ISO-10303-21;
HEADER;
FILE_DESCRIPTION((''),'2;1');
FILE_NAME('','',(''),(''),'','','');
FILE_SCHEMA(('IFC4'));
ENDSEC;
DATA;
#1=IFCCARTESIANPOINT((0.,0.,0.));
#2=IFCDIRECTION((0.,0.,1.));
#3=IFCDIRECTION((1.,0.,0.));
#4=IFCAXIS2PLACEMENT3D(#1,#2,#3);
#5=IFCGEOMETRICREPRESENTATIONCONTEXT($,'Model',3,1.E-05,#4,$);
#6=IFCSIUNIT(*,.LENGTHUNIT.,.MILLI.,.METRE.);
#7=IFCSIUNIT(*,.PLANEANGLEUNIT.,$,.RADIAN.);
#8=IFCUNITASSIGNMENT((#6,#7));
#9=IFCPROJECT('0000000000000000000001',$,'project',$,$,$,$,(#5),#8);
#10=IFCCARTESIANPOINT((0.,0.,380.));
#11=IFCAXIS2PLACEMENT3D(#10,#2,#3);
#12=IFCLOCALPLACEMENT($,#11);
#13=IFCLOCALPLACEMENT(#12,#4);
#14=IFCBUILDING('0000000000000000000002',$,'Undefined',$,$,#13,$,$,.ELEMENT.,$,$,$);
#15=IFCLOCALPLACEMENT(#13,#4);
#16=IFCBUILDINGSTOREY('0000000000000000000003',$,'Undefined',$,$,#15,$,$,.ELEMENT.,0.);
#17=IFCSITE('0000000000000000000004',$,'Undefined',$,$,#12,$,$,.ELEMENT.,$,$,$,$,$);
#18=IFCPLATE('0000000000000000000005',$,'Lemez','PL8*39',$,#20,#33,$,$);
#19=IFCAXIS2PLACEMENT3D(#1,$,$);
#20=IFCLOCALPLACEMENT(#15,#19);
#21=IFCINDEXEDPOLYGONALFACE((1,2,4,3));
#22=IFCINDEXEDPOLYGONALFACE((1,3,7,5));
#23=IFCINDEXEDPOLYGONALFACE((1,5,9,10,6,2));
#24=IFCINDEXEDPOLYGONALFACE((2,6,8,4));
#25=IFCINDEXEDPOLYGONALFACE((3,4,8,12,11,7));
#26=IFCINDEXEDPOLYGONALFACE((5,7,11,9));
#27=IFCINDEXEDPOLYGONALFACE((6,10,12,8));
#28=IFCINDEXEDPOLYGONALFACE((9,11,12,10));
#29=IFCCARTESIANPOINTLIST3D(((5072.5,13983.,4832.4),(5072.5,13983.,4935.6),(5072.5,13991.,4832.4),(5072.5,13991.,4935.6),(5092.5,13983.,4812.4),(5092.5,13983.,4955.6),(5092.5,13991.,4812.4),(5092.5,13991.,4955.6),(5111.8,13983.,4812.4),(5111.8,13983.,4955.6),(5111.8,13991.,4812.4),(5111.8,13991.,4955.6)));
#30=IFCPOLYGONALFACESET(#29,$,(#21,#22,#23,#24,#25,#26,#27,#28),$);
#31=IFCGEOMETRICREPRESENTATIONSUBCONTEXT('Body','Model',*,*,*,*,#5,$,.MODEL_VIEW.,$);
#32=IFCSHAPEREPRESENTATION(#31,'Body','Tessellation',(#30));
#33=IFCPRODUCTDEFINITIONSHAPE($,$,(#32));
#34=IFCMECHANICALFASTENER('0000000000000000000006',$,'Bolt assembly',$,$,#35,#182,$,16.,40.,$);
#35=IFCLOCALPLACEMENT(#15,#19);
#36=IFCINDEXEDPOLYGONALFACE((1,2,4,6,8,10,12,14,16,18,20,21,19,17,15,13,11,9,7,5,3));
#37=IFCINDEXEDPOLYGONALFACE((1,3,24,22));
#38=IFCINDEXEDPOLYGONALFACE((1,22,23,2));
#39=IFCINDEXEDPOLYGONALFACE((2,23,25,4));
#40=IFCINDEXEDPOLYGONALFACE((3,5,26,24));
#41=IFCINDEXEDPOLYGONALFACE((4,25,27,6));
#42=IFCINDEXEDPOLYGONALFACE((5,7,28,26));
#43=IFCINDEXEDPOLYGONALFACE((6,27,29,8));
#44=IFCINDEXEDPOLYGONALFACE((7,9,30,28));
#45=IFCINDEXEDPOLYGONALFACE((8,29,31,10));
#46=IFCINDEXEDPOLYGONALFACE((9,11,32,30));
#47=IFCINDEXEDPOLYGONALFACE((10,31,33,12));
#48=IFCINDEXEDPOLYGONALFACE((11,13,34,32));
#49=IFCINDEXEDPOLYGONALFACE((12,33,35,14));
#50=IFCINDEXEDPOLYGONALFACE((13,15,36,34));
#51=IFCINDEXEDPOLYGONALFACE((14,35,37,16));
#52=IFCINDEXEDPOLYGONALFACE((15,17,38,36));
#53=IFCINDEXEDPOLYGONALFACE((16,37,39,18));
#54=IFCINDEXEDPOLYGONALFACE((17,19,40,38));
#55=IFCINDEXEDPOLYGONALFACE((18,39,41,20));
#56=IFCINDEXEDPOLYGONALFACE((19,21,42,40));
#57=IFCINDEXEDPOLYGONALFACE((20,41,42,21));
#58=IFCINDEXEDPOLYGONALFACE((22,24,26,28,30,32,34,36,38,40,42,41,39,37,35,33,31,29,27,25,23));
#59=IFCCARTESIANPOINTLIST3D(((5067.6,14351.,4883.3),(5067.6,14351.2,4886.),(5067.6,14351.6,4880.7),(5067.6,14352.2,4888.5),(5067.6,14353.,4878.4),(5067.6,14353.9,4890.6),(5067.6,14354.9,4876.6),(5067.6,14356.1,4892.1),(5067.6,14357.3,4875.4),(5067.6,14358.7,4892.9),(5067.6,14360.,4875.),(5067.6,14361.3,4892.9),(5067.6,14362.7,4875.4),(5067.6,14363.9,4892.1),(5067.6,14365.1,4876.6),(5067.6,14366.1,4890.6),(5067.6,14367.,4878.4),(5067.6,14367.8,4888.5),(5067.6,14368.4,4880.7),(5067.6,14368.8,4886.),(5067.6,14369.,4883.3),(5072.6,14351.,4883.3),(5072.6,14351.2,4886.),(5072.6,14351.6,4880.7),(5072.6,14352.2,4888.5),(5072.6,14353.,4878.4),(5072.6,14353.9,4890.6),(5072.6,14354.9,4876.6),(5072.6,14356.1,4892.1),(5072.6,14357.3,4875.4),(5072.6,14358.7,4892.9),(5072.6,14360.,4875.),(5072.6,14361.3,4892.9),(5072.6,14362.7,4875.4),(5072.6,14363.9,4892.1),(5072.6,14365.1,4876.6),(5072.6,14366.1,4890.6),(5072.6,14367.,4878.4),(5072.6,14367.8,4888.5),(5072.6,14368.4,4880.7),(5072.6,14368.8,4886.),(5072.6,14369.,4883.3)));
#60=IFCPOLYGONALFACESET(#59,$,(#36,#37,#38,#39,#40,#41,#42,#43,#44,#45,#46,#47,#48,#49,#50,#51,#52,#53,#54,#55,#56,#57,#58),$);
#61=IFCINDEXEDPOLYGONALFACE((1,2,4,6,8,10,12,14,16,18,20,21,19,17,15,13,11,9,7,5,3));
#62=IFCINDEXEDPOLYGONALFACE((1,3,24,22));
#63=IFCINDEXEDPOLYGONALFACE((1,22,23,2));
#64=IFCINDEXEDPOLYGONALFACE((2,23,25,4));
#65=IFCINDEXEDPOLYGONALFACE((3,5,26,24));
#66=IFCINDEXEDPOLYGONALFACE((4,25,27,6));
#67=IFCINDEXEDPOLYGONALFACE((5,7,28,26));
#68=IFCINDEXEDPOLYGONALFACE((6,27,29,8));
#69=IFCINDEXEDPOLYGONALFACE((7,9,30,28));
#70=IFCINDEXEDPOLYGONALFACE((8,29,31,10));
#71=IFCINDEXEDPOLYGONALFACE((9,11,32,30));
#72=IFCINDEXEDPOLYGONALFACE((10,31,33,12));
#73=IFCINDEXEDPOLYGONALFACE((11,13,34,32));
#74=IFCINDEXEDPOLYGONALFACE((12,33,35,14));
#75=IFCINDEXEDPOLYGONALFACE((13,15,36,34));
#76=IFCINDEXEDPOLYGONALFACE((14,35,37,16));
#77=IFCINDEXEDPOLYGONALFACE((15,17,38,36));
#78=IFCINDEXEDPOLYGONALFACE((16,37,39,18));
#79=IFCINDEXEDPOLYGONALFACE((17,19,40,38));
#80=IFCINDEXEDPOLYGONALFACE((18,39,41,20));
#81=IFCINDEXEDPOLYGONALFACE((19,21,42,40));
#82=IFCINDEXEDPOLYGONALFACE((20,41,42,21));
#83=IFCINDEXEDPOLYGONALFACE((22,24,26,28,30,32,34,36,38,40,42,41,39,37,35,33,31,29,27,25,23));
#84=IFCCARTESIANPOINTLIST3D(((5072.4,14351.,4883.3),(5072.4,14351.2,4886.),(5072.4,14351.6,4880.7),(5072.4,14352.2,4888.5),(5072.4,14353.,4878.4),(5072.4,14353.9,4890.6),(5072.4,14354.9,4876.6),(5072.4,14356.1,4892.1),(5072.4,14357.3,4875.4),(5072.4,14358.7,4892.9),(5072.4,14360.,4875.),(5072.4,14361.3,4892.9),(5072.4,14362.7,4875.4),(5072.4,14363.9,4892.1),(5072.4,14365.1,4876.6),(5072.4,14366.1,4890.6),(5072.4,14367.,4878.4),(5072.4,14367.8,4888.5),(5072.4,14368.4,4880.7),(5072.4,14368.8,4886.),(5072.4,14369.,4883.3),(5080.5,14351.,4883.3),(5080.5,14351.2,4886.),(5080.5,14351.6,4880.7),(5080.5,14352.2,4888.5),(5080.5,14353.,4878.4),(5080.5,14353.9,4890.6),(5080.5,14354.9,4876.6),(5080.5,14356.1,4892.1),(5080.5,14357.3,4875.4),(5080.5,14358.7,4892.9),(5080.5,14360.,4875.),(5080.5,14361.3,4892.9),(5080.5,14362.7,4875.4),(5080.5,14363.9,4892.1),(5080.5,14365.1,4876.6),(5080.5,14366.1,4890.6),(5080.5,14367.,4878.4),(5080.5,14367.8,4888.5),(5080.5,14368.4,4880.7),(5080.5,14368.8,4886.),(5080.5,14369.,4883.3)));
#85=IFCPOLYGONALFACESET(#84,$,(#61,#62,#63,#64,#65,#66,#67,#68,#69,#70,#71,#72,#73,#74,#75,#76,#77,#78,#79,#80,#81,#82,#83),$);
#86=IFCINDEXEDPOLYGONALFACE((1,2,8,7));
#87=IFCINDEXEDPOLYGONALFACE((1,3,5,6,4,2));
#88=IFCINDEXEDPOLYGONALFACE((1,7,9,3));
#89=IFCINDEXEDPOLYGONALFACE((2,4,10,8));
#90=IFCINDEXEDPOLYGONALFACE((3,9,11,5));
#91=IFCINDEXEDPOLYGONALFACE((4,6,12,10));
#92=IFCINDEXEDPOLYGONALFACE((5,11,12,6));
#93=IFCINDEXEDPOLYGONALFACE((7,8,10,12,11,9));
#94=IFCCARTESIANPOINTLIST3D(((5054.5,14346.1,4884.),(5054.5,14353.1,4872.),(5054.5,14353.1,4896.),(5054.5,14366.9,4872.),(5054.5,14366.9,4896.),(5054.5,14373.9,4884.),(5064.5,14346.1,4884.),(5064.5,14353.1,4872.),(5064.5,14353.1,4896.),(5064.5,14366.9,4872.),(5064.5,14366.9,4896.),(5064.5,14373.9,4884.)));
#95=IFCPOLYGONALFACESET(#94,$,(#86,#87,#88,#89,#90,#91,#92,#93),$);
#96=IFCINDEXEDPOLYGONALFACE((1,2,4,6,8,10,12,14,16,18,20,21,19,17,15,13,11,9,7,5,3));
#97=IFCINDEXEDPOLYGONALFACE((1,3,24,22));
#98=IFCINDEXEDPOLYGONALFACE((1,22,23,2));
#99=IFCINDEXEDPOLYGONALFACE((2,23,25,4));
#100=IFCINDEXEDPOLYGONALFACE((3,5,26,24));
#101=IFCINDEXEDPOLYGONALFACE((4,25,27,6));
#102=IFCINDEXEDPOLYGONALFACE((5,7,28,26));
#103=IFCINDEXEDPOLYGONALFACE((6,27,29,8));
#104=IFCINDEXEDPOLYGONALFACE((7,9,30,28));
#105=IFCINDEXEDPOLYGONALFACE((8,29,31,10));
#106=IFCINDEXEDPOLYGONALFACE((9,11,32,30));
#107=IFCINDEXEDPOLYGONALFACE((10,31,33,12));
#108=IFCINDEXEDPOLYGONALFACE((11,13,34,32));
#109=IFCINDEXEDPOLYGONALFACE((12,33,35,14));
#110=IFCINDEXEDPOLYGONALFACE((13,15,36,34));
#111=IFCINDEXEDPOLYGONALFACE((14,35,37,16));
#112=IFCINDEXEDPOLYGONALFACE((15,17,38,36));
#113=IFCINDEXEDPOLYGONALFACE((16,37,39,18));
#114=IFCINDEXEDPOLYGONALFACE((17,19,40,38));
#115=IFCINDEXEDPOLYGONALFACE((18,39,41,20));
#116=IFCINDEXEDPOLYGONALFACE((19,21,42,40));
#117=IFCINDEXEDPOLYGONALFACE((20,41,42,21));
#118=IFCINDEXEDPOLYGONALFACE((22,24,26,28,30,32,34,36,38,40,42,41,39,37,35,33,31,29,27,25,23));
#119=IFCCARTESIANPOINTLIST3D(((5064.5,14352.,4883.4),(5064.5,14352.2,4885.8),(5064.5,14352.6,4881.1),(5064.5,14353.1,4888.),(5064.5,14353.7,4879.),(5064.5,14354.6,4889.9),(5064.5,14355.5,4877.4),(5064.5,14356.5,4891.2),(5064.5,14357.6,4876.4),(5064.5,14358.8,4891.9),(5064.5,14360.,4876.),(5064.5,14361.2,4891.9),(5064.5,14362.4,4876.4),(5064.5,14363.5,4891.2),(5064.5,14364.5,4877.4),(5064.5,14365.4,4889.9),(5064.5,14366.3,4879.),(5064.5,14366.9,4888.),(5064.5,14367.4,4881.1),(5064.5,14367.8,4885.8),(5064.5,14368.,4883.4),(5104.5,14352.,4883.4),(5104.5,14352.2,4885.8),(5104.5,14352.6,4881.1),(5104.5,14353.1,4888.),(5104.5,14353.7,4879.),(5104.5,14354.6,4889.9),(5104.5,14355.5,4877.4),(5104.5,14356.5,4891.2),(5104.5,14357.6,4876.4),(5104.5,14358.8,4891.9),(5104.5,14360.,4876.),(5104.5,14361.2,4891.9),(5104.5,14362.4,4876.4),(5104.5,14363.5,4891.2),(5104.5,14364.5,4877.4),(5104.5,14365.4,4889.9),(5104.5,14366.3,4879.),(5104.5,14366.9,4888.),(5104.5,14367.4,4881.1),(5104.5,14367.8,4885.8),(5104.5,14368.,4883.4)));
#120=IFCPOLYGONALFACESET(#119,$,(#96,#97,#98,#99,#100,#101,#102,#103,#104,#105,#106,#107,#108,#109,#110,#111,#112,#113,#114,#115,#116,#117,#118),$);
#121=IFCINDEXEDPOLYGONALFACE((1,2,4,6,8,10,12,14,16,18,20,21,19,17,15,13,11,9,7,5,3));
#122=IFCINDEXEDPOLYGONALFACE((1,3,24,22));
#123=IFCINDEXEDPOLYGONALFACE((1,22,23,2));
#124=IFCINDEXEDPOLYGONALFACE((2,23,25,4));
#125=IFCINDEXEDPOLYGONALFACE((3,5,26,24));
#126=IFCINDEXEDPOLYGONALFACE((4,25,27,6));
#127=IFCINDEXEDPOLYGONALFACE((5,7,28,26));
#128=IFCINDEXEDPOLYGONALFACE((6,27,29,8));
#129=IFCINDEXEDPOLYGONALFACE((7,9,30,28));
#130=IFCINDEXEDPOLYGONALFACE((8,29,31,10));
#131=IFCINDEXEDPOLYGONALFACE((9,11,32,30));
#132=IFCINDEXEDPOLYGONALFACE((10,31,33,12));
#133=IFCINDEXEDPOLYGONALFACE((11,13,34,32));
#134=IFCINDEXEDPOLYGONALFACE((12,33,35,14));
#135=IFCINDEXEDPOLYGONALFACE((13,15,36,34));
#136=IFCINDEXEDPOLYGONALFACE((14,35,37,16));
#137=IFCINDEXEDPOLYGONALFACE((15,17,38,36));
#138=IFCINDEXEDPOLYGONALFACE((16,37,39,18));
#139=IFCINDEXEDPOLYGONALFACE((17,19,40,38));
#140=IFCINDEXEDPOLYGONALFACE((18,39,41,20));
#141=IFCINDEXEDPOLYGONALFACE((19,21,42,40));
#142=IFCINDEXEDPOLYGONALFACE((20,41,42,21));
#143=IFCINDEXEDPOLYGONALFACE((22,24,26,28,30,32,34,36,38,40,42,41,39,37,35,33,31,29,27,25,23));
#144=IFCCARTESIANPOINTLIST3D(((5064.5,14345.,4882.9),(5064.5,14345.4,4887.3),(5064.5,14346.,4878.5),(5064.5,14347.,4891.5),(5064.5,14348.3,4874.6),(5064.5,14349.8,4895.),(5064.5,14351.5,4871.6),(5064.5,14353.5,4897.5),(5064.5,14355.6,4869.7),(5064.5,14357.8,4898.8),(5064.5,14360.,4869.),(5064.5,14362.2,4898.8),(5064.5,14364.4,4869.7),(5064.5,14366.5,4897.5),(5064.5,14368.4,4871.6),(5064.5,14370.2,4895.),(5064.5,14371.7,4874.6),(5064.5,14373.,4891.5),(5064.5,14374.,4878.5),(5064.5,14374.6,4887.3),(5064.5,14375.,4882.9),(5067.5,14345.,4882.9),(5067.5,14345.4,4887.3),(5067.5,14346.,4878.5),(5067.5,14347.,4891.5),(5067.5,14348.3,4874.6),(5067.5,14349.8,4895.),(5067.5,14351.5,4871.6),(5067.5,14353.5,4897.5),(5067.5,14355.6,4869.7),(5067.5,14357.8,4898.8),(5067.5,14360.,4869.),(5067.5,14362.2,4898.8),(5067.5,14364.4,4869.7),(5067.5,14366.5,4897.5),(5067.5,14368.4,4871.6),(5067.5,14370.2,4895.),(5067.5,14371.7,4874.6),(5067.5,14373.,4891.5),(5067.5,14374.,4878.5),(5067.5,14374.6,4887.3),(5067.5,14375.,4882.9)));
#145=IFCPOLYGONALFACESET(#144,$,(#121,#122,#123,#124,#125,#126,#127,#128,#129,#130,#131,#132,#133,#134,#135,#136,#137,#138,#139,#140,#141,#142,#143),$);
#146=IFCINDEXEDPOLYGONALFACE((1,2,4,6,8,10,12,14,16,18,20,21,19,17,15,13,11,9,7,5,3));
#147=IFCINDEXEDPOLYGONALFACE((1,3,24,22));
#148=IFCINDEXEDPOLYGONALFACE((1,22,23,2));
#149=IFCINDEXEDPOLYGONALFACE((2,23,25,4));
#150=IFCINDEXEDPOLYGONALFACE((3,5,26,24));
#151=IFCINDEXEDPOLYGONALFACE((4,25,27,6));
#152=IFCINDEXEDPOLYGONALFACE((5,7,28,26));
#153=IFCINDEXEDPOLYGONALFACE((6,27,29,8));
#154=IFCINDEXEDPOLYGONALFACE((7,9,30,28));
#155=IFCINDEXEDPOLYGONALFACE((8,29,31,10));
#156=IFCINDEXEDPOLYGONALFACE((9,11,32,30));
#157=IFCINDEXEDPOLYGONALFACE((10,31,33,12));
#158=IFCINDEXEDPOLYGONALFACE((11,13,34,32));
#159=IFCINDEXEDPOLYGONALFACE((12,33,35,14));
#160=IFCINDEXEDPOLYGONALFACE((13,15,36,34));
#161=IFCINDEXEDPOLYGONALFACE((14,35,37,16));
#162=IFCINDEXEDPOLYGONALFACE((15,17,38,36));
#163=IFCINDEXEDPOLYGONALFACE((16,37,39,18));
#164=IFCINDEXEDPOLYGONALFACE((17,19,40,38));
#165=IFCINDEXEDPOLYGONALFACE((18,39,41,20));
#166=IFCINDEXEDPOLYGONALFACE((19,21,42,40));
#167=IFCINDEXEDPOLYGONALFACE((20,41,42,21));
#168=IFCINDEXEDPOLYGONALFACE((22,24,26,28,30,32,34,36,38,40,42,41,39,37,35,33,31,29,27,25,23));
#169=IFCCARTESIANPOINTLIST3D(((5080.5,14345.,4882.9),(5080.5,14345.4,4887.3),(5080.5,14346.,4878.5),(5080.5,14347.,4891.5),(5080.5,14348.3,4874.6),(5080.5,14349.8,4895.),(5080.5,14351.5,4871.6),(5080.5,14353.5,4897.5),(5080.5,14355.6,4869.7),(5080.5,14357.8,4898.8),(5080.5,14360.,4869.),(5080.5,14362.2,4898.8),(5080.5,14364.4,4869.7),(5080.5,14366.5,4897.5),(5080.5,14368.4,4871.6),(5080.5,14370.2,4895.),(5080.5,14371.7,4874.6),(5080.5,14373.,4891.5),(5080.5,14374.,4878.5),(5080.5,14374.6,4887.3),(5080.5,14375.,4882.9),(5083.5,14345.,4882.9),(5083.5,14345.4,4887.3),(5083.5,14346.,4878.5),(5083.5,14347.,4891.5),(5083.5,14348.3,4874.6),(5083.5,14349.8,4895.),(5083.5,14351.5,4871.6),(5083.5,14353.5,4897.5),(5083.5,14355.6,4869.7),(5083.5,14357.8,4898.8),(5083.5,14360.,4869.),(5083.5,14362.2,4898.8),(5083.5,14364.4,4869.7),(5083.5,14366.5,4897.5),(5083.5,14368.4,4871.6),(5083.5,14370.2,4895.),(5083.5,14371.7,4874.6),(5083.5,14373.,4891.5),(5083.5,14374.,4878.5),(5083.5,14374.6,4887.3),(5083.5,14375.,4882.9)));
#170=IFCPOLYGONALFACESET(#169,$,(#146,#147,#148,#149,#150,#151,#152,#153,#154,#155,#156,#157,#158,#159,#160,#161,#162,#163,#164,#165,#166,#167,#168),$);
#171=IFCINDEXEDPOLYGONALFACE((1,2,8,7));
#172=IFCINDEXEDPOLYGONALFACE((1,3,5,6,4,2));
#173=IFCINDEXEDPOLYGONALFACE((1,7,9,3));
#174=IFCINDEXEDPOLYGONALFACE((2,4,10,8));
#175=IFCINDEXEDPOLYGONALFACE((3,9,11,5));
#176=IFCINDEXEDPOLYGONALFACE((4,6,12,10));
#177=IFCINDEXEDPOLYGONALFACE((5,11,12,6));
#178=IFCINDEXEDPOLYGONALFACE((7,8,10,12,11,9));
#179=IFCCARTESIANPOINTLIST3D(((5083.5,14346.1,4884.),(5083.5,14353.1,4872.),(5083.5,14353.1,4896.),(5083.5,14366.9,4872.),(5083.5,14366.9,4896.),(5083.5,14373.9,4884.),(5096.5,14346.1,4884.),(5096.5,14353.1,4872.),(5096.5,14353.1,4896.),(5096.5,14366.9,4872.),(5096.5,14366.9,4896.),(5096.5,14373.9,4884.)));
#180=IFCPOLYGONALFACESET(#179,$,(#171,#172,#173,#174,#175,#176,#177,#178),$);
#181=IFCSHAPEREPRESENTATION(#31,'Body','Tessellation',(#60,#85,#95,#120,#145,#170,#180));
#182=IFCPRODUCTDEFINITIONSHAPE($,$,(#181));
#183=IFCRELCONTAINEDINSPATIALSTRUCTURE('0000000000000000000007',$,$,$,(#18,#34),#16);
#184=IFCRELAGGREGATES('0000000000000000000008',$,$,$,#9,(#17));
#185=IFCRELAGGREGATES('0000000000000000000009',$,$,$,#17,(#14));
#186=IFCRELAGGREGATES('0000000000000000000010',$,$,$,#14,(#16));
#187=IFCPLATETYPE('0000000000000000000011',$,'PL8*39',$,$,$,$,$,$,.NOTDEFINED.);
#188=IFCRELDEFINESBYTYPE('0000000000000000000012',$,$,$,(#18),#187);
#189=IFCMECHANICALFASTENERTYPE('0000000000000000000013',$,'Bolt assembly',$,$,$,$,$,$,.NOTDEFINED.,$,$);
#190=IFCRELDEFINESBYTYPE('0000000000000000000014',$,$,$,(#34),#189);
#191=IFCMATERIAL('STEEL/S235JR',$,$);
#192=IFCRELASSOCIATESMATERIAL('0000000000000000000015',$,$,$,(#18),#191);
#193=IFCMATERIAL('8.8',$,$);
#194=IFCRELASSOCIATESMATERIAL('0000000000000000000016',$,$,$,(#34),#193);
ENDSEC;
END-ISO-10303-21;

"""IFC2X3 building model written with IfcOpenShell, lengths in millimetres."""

from ifc_helpers import new_model, si_unit, frame, origin_with_axes, origin_2d_with_axis, place, context, subcontext, project, spatial, polyline, circle, outline, extrude, source, transform, mapped, material, type_object, element, save


model = new_model("IFC2X3")

# Units and contexts
model_context = context("Model", 3, precision=1e-05, world=origin_with_axes())
body_context = subcontext(model_context, "Body", "Model", "MODEL_VIEW")
ifc_project = project(units=[si_unit("LENGTHUNIT", "METRE", prefix="MILLI"), si_unit("PLANEANGLEUNIT", "RADIAN")], contexts=[model_context])

# Site, building, storey
site_placement = place(None, frame((0.0, 0.0, 380.0), z_axis=(0.0, 0.0, 1.0), x_axis=(1.0, 0.0, 0.0)))
site = spatial("IfcSite", under=ifc_project, at=site_placement, Name="Undefined", CompositionType="ELEMENT")
building_placement = place(site_placement, origin_with_axes())
building = spatial("IfcBuilding", under=site, at=building_placement, Name="Undefined", CompositionType="ELEMENT")
storey_placement = place(building_placement, origin_with_axes())
storey = spatial("IfcBuildingStorey", under=building, at=storey_placement, Name="Undefined", CompositionType="ELEMENT", Elevation=0.0)

# Shared definitions
ifc_material_1 = material(Name="STEEL/S235JR")

# Plate
plate_type = type_object("IfcPlateType", Name="PL8*39", PredefinedType="NOTDEFINED")
plate_placement = place(storey_placement, frame((5072.5, 13987.0, 4812.4), z_axis=(0.0, -1.0, 0.0), x_axis=(1.0, 0.0, 0.0)))
element("IfcPlate", 1, at=plate_placement, inside=storey, type_object=plate_type, material=ifc_material_1, Name="Lemez", Description="PL8*39", context=body_context, shape_type="SweptSolid", body=[
    extrude(outline(polyline([(0.0, 20.0), (20.0, 0.0), (39.2, 0.0), (39.2, 143.2), (20.0, 143.2), (0.0, 123.2), (0.0, 20.0)])), frame((0.0, 0.0, -4.0), z_axis=(0.0, 0.0, 1.0), x_axis=(1.0, 0.0, 0.0)), (0.0, 0.0, 1.0), 8.0),
])

# Mechanical fastener
ifc_material_2 = material(Name="8.8")
mechanical_fastener_type = type_object("IfcMechanicalFastenerType", Name="Bolt assembly")
shared_shape_1 = source(origin_with_axes(), body_context, "Body", "SweptSolid", [
    extrude(circle(Radius=9.0, at=origin_2d_with_axis()), frame((0.0, -4.9, 0.0), z_axis=(0.0, 1.0, 0.0), x_axis=(1.0, 0.0, 0.0)), (0.0, 0.0, 1.0), 5.0),
    extrude(circle(Radius=9.0, at=origin_2d_with_axis()), frame((0.0, -0.1, 0.0), z_axis=(0.0, 1.0, 0.0), x_axis=(1.0, 0.0, 0.0)), (0.0, 0.0, 1.0), 8.1),
    extrude(outline(polyline([(12.0, -6.9), (12.0, 6.9), (0.0, 13.9), (-12.0, 6.9), (-12.0, -6.9), (0.0, -13.9), (12.0, -6.9)])), frame((0.0, -18.0, 0.0), z_axis=(0.0, 1.0, 0.0), x_axis=(1.0, 0.0, 0.0)), (0.0, 0.0, 1.0), 10.0),
    extrude(circle(Radius=8.0, at=origin_2d_with_axis()), frame((0.0, -8.0, 0.0), z_axis=(0.0, 1.0, 0.0), x_axis=(1.0, 0.0, 0.0)), (0.0, 0.0, 1.0), 40.0),
    extrude(circle(Radius=15.0, at=origin_2d_with_axis()), frame((0.0, -8.0, 0.0), z_axis=(0.0, 1.0, 0.0), x_axis=(1.0, 0.0, 0.0)), (0.0, 0.0, 1.0), 3.0),
    extrude(circle(Radius=15.0, at=origin_2d_with_axis()), frame((0.0, 8.0, 0.0), z_axis=(0.0, 1.0, 0.0), x_axis=(1.0, 0.0, 0.0)), (0.0, 0.0, 1.0), 3.0),
    extrude(outline(polyline([(12.0, -6.9), (12.0, 6.9), (0.0, 13.9), (-12.0, 6.9), (-12.0, -6.9), (0.0, -13.9), (12.0, -6.9)])), frame((0.0, 11.0, 0.0), z_axis=(0.0, 1.0, 0.0), x_axis=(1.0, 0.0, 0.0)), (0.0, 0.0, 1.0), 13.0),
])
mechanical_fastener_1_placement = place(storey_placement, frame((5072.5, 14397.5, 4964.0), z_axis=(0.0, -1.0, 0.0), x_axis=(0.0, 0.0, -1.0)))
element("IfcMechanicalFastener", 2, at=mechanical_fastener_1_placement, inside=storey, type_object=mechanical_fastener_type, material=ifc_material_2, Name="Bolt assembly", NominalDiameter=16.0, NominalLength=40.0, context=body_context, shape_type="MappedRepresentation", body=[
    mapped(shared_shape_1, transform((80.0, 0.0, 37.5))),
])

save(model, "model.ifc")
